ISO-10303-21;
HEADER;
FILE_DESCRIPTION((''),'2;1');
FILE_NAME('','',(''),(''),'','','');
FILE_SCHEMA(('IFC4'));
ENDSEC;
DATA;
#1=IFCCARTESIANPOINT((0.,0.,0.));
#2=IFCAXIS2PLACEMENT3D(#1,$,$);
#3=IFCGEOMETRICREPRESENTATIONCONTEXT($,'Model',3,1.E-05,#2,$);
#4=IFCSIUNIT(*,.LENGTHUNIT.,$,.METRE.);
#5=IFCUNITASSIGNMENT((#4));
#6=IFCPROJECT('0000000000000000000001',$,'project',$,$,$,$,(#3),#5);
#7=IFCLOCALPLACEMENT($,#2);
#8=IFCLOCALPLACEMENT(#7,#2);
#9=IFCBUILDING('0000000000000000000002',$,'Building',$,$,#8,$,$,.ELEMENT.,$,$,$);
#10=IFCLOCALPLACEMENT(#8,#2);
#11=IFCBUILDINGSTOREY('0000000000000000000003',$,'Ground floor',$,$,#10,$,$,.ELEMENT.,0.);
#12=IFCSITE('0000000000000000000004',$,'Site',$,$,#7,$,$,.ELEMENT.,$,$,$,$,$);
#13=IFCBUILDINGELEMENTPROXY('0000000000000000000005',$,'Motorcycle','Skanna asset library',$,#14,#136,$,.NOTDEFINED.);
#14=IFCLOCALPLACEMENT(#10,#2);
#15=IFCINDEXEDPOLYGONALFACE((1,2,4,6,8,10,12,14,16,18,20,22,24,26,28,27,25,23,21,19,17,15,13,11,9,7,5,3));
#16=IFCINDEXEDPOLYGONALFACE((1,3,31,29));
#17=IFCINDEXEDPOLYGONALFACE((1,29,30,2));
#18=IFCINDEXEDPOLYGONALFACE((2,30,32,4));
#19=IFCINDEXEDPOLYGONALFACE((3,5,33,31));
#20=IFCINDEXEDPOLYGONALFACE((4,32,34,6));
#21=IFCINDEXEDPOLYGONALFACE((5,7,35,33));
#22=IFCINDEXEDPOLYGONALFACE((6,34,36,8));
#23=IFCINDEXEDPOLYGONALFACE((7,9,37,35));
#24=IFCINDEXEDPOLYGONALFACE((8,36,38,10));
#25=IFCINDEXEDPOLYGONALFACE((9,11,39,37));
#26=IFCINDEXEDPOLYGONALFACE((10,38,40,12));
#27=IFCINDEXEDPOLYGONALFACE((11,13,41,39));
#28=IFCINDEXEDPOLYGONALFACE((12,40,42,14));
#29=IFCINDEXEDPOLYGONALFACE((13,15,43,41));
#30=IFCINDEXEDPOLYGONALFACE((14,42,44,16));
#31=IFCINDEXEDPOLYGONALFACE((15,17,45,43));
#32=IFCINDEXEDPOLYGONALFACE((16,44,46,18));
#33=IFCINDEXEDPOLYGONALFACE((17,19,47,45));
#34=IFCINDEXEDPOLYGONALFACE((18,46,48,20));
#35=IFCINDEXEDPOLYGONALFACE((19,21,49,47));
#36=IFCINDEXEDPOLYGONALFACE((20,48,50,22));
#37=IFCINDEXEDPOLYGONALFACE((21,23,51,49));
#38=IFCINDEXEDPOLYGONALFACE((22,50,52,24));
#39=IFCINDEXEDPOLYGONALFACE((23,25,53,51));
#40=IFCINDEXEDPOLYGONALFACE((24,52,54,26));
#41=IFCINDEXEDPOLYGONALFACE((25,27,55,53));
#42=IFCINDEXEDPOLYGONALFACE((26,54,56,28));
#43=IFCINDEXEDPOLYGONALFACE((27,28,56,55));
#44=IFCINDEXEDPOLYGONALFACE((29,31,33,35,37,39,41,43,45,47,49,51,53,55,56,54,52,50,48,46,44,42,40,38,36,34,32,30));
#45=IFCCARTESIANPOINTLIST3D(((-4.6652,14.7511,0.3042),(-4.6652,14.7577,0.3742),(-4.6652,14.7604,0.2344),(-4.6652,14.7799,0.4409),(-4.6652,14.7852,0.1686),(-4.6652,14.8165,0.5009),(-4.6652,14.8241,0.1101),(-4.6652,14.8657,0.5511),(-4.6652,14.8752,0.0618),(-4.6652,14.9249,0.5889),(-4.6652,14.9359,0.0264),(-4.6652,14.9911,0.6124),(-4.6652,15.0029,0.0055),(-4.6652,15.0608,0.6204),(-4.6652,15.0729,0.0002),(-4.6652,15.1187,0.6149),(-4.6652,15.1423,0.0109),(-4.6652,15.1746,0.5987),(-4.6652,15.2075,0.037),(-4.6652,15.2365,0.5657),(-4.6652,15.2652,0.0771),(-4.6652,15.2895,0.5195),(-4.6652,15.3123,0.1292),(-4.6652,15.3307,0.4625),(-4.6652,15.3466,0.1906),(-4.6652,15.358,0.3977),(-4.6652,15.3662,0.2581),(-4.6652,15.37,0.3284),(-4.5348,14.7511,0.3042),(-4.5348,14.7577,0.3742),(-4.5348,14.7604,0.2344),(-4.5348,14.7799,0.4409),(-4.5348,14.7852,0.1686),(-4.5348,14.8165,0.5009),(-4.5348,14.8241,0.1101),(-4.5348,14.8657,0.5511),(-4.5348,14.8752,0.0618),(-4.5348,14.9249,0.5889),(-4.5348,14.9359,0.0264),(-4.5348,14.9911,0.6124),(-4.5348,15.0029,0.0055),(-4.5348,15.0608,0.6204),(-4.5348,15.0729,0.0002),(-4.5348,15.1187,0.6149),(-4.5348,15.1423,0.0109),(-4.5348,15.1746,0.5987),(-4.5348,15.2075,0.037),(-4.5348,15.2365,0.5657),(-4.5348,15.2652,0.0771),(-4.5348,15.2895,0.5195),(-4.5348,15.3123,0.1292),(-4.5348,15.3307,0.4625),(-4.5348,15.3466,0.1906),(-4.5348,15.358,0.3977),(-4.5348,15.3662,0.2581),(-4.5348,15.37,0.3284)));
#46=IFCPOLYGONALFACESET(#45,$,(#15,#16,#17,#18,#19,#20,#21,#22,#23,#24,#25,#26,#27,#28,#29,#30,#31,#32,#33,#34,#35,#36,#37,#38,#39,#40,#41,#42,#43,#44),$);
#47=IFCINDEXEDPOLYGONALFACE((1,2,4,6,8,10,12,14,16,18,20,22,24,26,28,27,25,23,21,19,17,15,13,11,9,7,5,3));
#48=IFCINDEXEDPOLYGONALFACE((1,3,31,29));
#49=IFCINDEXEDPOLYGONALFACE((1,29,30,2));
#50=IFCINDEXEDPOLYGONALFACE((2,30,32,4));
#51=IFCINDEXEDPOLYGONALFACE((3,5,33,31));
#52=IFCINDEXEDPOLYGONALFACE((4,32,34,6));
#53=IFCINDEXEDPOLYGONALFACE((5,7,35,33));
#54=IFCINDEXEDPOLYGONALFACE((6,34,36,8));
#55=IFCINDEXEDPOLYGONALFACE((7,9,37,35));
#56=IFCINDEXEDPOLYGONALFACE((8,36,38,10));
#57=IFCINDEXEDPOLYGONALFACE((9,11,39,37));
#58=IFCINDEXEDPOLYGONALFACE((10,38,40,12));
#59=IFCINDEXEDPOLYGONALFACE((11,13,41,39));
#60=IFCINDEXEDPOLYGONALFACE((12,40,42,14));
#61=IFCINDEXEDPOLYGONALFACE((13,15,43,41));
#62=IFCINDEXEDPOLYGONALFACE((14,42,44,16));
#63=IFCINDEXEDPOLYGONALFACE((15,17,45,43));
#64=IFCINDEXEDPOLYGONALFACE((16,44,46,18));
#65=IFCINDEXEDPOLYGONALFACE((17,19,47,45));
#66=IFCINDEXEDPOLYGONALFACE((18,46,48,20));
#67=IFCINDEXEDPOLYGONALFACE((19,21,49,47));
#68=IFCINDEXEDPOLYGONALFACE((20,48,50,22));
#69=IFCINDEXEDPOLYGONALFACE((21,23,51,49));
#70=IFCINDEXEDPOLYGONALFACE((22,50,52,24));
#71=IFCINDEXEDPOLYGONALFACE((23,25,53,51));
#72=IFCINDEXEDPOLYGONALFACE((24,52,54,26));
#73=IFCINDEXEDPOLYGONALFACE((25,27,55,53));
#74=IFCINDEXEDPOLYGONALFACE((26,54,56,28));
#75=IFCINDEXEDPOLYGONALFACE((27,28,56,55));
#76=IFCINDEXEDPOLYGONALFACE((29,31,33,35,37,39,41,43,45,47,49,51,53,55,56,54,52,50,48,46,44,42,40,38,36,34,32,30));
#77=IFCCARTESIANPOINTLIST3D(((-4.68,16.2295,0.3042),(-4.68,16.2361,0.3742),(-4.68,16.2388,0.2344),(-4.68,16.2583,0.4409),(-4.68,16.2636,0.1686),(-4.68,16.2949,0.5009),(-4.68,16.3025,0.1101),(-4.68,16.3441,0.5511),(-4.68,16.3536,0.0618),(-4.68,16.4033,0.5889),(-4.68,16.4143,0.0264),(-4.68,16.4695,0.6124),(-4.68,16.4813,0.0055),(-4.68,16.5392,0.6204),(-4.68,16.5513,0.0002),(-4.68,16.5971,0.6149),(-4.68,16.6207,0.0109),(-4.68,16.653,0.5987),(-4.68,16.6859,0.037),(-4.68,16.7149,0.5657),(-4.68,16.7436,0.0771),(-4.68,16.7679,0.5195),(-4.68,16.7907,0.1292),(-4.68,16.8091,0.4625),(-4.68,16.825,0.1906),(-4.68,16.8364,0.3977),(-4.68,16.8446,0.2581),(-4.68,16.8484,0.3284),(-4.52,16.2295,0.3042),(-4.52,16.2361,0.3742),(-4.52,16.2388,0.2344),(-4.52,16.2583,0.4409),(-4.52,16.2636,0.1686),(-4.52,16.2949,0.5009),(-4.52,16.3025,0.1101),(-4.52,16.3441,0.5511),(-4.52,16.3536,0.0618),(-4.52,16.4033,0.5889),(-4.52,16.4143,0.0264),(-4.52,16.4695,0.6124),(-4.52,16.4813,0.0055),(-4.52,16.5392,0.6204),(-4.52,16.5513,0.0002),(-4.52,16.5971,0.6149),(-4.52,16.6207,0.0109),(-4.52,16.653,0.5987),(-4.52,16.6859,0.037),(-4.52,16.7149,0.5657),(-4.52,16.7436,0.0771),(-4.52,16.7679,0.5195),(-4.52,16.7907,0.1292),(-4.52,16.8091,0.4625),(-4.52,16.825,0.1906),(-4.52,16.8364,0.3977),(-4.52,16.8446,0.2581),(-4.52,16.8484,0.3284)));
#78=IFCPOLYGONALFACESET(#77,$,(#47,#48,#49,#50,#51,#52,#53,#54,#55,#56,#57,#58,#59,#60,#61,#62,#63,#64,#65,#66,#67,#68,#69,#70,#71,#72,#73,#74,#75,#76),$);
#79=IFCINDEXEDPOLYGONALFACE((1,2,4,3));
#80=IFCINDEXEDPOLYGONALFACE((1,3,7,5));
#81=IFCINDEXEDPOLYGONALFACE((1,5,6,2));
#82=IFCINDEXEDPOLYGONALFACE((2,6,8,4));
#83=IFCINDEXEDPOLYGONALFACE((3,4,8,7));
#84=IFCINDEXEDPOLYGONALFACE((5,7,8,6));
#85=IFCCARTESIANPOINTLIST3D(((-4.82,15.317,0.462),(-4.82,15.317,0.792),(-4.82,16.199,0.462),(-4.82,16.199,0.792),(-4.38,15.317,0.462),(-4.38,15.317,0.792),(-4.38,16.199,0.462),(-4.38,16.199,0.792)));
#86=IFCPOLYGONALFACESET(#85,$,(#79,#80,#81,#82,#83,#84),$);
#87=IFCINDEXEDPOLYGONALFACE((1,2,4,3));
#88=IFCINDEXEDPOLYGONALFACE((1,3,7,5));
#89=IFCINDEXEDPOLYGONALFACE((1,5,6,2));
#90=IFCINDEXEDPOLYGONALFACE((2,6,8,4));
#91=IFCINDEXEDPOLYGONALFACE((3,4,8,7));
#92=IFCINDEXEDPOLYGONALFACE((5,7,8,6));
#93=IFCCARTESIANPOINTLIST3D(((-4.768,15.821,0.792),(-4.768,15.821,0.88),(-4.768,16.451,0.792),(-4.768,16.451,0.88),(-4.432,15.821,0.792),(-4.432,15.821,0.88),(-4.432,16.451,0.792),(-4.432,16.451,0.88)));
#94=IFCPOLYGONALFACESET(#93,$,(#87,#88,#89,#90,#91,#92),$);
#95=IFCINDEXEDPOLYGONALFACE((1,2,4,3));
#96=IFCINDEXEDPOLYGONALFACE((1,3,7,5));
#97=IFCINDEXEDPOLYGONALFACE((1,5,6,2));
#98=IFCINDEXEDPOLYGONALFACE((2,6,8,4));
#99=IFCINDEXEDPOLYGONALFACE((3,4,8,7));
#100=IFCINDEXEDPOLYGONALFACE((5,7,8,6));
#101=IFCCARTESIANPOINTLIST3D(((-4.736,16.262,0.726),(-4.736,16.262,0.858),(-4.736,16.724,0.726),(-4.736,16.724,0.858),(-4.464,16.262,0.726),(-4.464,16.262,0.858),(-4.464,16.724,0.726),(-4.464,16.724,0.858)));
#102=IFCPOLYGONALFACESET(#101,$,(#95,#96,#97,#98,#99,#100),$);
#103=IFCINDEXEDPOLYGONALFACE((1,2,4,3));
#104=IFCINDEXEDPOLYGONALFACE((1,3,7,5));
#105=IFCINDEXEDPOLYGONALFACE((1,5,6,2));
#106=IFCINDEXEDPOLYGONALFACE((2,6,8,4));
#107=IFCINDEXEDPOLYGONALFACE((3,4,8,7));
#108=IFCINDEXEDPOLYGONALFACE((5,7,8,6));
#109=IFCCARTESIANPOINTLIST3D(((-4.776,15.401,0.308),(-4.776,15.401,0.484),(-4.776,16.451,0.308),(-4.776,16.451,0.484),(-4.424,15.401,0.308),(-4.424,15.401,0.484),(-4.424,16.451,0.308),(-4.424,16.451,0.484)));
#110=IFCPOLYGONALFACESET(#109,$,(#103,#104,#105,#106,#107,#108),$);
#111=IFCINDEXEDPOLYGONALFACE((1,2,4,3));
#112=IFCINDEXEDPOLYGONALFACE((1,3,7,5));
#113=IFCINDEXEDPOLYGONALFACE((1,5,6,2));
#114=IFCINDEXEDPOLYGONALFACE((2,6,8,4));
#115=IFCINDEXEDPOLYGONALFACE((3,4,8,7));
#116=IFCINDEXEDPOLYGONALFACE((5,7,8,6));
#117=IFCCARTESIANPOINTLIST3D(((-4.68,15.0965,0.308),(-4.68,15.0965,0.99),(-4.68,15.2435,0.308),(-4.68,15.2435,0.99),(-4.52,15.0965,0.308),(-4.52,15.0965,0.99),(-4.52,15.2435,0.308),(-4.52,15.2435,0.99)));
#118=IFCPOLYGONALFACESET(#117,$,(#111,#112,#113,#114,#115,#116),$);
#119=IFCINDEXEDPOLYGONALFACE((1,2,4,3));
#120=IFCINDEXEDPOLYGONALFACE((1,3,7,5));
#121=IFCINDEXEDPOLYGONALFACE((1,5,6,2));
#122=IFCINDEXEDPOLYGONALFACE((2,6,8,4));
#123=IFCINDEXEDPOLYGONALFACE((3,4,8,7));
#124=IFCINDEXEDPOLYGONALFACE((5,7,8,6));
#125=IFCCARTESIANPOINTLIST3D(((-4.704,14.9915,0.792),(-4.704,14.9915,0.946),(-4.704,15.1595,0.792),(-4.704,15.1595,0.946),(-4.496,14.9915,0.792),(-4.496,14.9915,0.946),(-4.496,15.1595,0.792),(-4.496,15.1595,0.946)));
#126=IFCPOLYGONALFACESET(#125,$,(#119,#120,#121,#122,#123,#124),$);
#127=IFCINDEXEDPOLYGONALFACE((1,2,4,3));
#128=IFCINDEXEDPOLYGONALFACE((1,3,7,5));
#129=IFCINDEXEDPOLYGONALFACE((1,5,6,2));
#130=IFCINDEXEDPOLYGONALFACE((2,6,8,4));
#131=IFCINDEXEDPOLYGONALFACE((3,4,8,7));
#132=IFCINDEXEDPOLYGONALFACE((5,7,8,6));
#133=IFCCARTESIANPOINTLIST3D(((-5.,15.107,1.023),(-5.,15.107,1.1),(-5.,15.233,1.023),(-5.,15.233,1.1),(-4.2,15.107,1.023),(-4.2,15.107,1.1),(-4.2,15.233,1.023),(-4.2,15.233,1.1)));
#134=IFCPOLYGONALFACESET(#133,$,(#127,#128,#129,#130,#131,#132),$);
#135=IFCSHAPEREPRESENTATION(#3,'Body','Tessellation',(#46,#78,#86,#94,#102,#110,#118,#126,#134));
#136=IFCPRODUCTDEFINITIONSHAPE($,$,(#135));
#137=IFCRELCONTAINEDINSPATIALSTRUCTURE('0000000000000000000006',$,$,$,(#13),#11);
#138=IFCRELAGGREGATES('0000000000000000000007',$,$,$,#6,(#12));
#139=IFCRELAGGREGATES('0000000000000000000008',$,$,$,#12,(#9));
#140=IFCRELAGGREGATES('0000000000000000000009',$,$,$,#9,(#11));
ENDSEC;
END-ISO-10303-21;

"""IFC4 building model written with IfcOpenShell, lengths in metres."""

from ifc_helpers import new_model, si_unit, frame, frame_2d, origin, origin_2d, place, context, project, spatial, rectangle, ellipse, extrude, element, save


model = new_model("IFC4")

# Units and contexts
model_context = context("Model", 3, precision=1e-05, world=origin())
ifc_project = project(units=[si_unit("LENGTHUNIT", "METRE")], contexts=[model_context])

# Site, building, storey
site_placement = place(None, origin())
site = spatial("IfcSite", under=ifc_project, at=site_placement, Name="Site", CompositionType="ELEMENT")
building_placement = place(site_placement, origin())
building = spatial("IfcBuilding", under=site, at=building_placement, Name="Building", CompositionType="ELEMENT")
storey_placement = place(building_placement, origin())
storey = spatial("IfcBuildingStorey", under=building, at=storey_placement, Name="Ground floor", CompositionType="ELEMENT", Elevation=0.0)

# Building element proxy
proxy_1_placement = place(storey_placement, frame((-4.6, 15.8, 0.0), z_axis=(0.0, 0.0, 1.0), x_axis=(1.0, 0.0, 0.0)))
element("IfcBuildingElementProxy", 1, at=proxy_1_placement, inside=storey, Name="Motorcycle", Description="Skanna asset library", PredefinedType="NOTDEFINED", context=model_context, shape_type="SweptSolid", body=[
    extrude(ellipse(SemiAxis1=0.3098, SemiAxis2=0.3102, at=origin_2d()), frame((-0.0652, -0.7392, 0.3102), z_axis=(1.0, 0.0, 0.0), x_axis=(0.0, 1.0, 0.0)), (0.0, 0.0, 1.0), 0.1304),
    extrude(ellipse(SemiAxis1=0.3098, SemiAxis2=0.3102, at=origin_2d()), frame((-0.08, 0.7392, 0.3102), z_axis=(1.0, 0.0, 0.0), x_axis=(0.0, 1.0, 0.0)), (0.0, 0.0, 1.0), 0.16),
    extrude(rectangle(XDim=0.44, YDim=0.882, at=frame_2d((0.0, -0.042))), frame((0.0, 0.0, 0.462)), (0.0, 0.0, 1.0), 0.33),
    extrude(rectangle(XDim=0.336, YDim=0.63, at=frame_2d((0.0, 0.336))), frame((0.0, 0.0, 0.792)), (0.0, 0.0, 1.0), 0.088),
    extrude(rectangle(XDim=0.272, YDim=0.462, at=frame_2d((0.0, 0.693))), frame((0.0, 0.0, 0.726)), (0.0, 0.0, 1.0), 0.132),
    extrude(rectangle(XDim=0.352, YDim=1.05, at=frame_2d((0.0, 0.126))), frame((0.0, 0.0, 0.308)), (0.0, 0.0, 1.0), 0.176),
    extrude(rectangle(XDim=0.16, YDim=0.147, at=frame_2d((0.0, -0.63))), frame((0.0, 0.0, 0.308)), (0.0, 0.0, 1.0), 0.682),
    extrude(rectangle(XDim=0.208, YDim=0.168, at=frame_2d((0.0, -0.7245))), frame((0.0, 0.0, 0.792)), (0.0, 0.0, 1.0), 0.154),
    extrude(rectangle(XDim=0.8, YDim=0.126, at=frame_2d((0.0, -0.63))), frame((0.0, 0.0, 1.023)), (0.0, 0.0, 1.0), 0.077),
])

save(model, "model.ifc")
